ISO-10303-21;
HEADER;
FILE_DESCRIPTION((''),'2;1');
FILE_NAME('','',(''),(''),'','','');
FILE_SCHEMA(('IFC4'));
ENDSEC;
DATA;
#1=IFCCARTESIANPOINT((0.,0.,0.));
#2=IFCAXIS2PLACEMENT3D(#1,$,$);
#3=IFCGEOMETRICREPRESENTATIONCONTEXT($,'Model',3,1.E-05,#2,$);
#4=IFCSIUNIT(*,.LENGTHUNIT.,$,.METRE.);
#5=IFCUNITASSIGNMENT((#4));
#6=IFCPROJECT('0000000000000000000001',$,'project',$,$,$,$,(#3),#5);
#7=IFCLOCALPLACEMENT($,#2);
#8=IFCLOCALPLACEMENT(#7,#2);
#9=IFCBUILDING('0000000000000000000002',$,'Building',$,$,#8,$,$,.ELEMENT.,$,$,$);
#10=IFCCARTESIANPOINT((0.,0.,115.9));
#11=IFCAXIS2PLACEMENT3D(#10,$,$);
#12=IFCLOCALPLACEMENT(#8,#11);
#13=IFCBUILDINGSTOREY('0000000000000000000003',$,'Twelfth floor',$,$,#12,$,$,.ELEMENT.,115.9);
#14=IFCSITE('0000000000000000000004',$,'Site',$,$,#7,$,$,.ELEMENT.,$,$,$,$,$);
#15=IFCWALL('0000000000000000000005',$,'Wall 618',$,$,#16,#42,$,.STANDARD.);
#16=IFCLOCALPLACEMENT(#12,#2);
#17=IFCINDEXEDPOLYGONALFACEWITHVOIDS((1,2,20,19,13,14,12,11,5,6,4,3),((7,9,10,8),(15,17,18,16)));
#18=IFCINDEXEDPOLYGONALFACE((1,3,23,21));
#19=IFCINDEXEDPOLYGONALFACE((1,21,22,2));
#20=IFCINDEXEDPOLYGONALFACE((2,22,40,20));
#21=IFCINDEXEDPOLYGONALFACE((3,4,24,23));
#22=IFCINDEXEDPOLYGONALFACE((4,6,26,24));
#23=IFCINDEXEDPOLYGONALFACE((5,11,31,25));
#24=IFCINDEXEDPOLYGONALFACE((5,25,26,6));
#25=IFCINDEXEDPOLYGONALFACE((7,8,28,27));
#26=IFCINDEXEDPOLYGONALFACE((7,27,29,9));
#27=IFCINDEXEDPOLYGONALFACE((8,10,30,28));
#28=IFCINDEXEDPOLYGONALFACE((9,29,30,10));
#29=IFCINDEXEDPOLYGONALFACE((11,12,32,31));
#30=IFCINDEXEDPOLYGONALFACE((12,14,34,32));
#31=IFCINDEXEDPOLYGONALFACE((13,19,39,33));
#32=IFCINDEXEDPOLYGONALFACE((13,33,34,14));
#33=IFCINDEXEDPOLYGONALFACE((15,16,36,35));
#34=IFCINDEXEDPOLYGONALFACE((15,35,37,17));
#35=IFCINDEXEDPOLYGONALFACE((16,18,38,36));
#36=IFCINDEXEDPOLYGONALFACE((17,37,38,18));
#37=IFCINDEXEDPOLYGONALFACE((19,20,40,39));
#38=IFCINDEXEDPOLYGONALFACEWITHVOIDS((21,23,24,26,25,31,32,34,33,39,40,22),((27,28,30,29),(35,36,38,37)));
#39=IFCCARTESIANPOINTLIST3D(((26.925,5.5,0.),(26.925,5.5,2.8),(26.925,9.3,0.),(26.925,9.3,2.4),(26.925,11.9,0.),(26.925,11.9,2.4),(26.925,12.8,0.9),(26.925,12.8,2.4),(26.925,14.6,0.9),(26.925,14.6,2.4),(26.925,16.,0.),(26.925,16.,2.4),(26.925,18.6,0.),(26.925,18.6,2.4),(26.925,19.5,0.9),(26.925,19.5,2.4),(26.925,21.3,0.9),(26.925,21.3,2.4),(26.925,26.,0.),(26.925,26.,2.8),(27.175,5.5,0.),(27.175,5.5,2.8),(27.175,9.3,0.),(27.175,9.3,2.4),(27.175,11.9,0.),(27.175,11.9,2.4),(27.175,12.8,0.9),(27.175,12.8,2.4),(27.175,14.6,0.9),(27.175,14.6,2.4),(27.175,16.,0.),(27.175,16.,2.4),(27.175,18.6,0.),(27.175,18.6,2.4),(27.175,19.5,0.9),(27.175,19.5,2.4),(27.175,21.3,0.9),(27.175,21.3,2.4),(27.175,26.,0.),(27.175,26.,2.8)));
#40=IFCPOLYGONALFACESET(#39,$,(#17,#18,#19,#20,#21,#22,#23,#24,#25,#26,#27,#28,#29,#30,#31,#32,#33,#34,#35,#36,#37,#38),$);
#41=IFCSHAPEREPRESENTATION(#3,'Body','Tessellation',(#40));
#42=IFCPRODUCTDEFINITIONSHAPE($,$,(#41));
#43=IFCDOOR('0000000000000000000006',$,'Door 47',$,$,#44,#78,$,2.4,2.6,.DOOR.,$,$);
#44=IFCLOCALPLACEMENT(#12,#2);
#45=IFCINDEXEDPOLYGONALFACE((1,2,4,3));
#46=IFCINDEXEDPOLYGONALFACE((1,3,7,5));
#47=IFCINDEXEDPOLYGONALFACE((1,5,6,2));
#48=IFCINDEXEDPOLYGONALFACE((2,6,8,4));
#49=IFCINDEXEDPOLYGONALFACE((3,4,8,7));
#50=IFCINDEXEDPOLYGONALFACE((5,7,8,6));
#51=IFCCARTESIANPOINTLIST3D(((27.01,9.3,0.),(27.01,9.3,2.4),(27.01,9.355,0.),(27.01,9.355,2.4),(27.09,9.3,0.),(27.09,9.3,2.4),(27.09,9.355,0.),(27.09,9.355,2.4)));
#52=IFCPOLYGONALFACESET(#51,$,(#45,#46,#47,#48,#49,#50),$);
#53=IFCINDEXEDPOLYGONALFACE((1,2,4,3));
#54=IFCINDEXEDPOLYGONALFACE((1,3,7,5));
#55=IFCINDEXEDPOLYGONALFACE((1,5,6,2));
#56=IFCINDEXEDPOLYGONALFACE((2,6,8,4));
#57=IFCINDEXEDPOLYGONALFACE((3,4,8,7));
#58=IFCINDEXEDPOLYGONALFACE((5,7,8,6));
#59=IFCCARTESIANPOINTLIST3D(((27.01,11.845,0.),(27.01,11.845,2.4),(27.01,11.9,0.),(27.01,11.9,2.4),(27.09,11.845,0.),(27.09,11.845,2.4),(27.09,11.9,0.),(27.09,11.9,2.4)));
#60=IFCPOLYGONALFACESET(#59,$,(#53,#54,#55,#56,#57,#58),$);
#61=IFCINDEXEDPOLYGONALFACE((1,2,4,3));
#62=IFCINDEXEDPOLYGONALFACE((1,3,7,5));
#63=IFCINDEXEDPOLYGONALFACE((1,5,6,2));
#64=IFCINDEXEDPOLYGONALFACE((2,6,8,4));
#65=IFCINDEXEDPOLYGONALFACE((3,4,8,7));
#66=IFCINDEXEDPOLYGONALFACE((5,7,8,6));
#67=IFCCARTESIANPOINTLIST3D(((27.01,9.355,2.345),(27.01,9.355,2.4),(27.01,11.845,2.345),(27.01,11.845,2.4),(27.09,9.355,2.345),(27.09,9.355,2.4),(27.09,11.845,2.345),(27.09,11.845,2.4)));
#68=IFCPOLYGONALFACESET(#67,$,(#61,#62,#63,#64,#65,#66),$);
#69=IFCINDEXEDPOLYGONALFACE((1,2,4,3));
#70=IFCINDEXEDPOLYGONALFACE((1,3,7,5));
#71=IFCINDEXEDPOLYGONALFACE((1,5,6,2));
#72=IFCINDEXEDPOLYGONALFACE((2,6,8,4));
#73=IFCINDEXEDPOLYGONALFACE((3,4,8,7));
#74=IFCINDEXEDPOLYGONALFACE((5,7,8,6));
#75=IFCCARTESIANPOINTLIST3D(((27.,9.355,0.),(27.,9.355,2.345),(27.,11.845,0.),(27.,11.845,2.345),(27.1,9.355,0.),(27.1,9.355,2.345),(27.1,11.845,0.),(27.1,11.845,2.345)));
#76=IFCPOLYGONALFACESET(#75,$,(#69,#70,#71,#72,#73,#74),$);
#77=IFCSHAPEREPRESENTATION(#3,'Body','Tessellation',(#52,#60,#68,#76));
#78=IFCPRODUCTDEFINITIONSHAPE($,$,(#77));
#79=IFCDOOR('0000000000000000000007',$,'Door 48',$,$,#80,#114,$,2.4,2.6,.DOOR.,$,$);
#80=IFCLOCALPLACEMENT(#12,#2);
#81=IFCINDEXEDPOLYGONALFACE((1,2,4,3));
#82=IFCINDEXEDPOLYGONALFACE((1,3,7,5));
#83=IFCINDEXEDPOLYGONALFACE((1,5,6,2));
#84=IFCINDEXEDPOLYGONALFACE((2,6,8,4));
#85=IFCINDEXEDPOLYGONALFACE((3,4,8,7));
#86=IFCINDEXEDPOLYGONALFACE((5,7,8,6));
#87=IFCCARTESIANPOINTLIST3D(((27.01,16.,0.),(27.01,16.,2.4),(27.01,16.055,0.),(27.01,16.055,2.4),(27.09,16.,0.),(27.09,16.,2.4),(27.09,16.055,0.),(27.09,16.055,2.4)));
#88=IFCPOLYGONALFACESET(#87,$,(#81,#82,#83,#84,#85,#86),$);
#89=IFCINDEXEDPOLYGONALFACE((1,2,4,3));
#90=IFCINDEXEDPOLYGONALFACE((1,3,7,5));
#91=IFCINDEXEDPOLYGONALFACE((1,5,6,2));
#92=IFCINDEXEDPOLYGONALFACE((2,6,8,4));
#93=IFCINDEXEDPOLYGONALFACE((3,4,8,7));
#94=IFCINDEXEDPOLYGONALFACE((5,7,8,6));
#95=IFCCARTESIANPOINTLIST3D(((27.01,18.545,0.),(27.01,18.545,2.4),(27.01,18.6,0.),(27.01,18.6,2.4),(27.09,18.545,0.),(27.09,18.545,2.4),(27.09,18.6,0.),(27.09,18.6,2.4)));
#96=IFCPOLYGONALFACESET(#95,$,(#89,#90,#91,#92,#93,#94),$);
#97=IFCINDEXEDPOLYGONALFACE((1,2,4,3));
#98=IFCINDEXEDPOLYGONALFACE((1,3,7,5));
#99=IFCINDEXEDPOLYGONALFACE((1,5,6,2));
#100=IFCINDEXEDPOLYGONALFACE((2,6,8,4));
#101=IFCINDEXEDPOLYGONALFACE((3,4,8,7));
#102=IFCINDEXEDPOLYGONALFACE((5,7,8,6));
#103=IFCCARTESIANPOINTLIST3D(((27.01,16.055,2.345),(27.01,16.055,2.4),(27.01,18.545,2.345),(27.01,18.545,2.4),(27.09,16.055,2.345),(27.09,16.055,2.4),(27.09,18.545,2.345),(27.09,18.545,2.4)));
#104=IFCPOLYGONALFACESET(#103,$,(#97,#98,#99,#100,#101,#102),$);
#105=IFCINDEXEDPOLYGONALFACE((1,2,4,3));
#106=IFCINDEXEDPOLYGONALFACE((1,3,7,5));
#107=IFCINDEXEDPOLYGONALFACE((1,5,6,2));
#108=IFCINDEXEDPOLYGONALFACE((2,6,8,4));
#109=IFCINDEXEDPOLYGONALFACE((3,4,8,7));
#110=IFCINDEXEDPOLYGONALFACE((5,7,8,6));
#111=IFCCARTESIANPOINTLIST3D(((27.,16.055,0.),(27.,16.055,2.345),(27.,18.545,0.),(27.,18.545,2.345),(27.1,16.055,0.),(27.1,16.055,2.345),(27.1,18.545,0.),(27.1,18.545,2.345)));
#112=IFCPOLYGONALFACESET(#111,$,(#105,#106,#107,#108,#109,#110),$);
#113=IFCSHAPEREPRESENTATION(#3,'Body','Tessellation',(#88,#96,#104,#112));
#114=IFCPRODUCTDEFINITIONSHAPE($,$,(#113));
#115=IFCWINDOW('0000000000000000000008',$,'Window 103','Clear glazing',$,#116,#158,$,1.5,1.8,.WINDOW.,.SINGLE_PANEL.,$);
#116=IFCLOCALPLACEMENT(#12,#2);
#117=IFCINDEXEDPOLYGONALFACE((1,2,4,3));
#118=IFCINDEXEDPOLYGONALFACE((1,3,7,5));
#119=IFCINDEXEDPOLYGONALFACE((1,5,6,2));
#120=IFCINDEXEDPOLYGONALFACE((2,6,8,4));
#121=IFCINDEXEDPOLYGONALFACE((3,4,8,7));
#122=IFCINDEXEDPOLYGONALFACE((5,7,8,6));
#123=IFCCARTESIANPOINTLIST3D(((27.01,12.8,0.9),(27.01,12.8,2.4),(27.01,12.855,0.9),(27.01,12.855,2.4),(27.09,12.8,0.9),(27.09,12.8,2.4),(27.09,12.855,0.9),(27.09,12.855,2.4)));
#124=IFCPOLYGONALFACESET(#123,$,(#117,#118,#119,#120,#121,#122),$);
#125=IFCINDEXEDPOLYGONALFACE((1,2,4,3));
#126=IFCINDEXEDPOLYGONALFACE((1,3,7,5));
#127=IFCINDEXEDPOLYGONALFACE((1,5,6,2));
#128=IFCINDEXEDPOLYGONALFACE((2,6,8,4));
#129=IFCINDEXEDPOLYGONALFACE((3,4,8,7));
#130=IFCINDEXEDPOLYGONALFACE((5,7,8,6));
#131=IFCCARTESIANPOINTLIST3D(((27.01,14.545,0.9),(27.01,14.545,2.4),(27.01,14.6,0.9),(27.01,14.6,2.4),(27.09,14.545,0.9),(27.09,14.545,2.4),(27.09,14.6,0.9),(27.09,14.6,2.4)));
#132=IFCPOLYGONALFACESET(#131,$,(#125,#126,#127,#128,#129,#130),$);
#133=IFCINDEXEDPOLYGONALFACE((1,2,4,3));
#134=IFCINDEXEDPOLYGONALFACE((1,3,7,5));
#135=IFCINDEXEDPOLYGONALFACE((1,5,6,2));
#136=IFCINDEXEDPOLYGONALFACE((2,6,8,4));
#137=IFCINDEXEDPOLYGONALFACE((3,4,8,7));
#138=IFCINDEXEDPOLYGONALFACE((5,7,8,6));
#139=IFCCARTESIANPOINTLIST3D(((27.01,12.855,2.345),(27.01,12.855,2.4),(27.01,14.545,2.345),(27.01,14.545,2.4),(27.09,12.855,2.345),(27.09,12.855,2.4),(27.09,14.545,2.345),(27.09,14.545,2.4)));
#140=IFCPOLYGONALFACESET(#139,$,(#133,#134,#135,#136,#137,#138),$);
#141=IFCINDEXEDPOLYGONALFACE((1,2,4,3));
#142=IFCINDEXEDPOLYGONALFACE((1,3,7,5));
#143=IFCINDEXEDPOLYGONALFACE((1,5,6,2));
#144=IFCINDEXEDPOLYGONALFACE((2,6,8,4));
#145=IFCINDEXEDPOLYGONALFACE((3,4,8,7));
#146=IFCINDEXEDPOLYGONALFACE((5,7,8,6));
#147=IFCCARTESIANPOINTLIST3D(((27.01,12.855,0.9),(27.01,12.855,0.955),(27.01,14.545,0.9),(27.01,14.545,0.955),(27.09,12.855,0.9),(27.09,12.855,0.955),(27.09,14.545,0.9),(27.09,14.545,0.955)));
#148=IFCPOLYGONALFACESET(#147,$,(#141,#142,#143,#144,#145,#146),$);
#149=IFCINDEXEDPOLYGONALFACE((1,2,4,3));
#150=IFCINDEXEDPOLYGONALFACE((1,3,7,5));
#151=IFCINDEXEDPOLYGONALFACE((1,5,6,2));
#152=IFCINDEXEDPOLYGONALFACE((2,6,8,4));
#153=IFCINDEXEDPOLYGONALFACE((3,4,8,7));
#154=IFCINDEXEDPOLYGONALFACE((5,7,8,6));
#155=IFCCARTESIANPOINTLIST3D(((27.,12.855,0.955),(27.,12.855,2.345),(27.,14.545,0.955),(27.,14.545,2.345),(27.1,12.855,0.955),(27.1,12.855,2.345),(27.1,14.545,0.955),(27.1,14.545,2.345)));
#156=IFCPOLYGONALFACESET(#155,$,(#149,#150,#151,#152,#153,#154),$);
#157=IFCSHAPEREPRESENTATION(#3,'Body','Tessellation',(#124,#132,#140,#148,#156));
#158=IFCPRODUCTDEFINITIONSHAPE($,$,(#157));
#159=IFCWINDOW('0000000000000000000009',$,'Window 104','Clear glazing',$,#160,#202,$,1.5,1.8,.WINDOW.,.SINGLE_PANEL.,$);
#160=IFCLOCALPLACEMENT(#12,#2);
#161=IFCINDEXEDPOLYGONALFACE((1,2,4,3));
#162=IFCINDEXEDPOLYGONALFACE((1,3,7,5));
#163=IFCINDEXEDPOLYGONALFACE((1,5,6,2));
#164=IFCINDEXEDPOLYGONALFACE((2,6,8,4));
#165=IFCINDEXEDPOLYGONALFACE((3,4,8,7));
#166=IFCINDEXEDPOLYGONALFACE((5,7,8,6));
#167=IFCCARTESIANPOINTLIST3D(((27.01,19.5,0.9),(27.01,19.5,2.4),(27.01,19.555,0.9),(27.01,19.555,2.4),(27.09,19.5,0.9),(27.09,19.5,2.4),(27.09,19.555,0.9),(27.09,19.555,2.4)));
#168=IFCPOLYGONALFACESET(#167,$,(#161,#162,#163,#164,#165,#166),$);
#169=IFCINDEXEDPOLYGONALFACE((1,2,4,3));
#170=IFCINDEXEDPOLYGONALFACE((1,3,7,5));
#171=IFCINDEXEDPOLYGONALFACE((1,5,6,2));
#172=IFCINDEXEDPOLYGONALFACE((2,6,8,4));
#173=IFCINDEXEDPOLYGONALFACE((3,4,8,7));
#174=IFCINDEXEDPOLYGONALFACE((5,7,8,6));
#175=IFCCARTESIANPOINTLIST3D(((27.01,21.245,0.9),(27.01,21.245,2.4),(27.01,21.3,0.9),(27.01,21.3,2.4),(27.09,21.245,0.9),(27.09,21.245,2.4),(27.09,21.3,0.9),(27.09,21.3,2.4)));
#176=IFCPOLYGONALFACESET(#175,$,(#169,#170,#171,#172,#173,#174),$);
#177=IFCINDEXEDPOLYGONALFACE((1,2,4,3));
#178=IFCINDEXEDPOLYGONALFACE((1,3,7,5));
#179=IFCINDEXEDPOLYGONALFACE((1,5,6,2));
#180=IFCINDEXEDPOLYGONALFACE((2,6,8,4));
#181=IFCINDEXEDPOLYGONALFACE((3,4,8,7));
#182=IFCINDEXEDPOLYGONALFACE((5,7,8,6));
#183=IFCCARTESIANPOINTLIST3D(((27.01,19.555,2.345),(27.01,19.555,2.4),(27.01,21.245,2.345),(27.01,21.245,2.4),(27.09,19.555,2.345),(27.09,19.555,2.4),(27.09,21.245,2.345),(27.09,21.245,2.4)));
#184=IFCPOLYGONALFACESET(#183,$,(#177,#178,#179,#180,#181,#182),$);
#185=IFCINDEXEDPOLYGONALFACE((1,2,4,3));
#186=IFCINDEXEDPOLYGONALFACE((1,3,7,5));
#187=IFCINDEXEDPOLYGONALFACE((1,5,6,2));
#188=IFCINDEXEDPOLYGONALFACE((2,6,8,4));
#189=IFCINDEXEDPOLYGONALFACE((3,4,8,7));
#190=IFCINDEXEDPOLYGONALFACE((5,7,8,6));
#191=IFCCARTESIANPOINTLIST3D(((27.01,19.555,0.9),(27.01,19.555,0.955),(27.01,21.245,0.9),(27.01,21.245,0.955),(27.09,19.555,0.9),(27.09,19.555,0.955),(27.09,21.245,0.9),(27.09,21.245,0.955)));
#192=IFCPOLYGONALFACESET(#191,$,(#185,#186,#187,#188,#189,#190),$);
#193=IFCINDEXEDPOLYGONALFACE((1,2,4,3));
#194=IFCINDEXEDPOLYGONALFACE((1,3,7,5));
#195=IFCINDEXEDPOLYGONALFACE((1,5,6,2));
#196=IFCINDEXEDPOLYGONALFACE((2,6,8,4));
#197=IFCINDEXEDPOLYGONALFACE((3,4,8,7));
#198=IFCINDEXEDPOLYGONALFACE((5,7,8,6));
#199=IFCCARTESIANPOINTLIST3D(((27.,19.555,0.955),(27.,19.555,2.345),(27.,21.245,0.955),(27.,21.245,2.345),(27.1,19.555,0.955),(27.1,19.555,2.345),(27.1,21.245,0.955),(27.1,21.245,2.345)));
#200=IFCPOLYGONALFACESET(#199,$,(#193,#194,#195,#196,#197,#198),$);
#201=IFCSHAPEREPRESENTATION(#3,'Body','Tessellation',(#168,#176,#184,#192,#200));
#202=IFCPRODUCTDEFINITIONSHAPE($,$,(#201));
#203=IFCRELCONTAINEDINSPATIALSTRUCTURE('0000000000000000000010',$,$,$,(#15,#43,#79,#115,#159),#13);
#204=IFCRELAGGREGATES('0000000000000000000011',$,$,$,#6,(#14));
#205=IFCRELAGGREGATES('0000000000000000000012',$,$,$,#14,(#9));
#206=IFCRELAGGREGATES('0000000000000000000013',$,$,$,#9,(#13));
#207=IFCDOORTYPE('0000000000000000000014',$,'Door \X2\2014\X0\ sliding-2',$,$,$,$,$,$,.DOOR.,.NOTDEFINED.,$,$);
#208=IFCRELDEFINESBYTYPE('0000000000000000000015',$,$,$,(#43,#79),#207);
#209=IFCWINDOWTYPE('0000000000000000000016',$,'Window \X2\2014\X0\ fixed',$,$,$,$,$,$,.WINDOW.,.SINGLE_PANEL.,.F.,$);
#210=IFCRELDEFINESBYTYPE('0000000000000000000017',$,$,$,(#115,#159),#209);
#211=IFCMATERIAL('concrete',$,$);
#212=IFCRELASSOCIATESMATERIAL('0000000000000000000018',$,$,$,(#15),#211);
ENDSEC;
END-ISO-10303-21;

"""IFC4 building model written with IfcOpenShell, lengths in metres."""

from ifc_helpers import new_model, si_unit, frame, frame_2d, origin, place, context, project, spatial, rectangle, extrude, material, type_object, element, fill, save


model = new_model("IFC4")

# Units and contexts
model_context = context("Model", 3, precision=1e-05, world=origin())
ifc_project = project(units=[si_unit("LENGTHUNIT", "METRE")], contexts=[model_context])

# Site, building, storey
site_placement = place(None, origin())
site = spatial("IfcSite", under=ifc_project, at=site_placement, Name="Site", CompositionType="ELEMENT")
building_placement = place(site_placement, origin())
building = spatial("IfcBuilding", under=site, at=building_placement, Name="Building", CompositionType="ELEMENT")
storey_placement = place(building_placement, frame((0.0, 0.0, 115.9)))
storey = spatial("IfcBuildingStorey", under=building, at=storey_placement, Name="Twelfth floor", CompositionType="ELEMENT", Elevation=115.9)

# Shared definitions
ifc_material = material(Name="concrete")

# Wall, openings, doors, windows
wall_1_placement = place(storey_placement, frame((27.05, 5.5, 0.0), z_axis=(0.0, 0.0, 1.0), x_axis=(0.0, 1.0, 0.0)))
wall_1 = element("IfcWall", 1, at=wall_1_placement, inside=storey, material=ifc_material, Name="Wall 618", PredefinedType="STANDARD", context=model_context, shape_type="SweptSolid", body=[
    extrude(rectangle(XDim=20.5, YDim=0.25, at=frame_2d((10.25, 0.0))), origin(), (0.0, 0.0, 1.0), 2.8),
])
opening_1_placement = place(storey_placement, frame((27.05, 9.3, 0.0), z_axis=(0.0, 0.0, 1.0), x_axis=(0.0, 1.0, 0.0)))
opening_1 = element("IfcOpeningElement", 2, at=opening_1_placement, cuts=wall_1, PredefinedType="OPENING", context=model_context, shape_type="SweptSolid", body=[
    extrude(rectangle(XDim=2.6, YDim=0.31, at=frame_2d((1.3, 0.0))), origin(), (0.0, 0.0, 1.0), 2.4),
])
opening_2_placement = place(storey_placement, frame((27.05, 12.8, 0.9), z_axis=(0.0, 0.0, 1.0), x_axis=(0.0, 1.0, 0.0)))
opening_2 = element("IfcOpeningElement", 3, at=opening_2_placement, cuts=wall_1, PredefinedType="OPENING", context=model_context, shape_type="SweptSolid", body=[
    extrude(rectangle(XDim=1.8, YDim=0.31, at=frame_2d((0.9, 0.0))), origin(), (0.0, 0.0, 1.0), 1.5),
])
opening_3_placement = place(storey_placement, frame((27.05, 16.0, 0.0), z_axis=(0.0, 0.0, 1.0), x_axis=(0.0, 1.0, 0.0)))
opening_3 = element("IfcOpeningElement", 4, at=opening_3_placement, cuts=wall_1, PredefinedType="OPENING", context=model_context, shape_type="SweptSolid", body=[
    extrude(rectangle(XDim=2.6, YDim=0.31, at=frame_2d((1.3, 0.0))), origin(), (0.0, 0.0, 1.0), 2.4),
])
opening_4_placement = place(storey_placement, frame((27.05, 19.5, 0.9), z_axis=(0.0, 0.0, 1.0), x_axis=(0.0, 1.0, 0.0)))
opening_4 = element("IfcOpeningElement", 5, at=opening_4_placement, cuts=wall_1, PredefinedType="OPENING", context=model_context, shape_type="SweptSolid", body=[
    extrude(rectangle(XDim=1.8, YDim=0.31, at=frame_2d((0.9, 0.0))), origin(), (0.0, 0.0, 1.0), 1.5),
])
door_type = type_object("IfcDoorType", Name="Door — sliding-2", PredefinedType="DOOR")
door_1_placement = place(storey_placement, frame((27.05, 9.3, 0.0), z_axis=(0.0, 0.0, 1.0), x_axis=(0.0, 1.0, 0.0)))
door_1 = element("IfcDoor", 6, at=door_1_placement, inside=storey, type_object=door_type, Name="Door 47", OverallHeight=2.4, OverallWidth=2.6, PredefinedType="DOOR", context=model_context, shape_type="SweptSolid", body=[
    extrude(rectangle(XDim=0.055, YDim=0.08, at=frame_2d((0.0275, 0.0))), origin(), (0.0, 0.0, 1.0), 2.4),
    extrude(rectangle(XDim=0.055, YDim=0.08, at=frame_2d((2.5725, 0.0))), origin(), (0.0, 0.0, 1.0), 2.4),
    extrude(rectangle(XDim=2.49, YDim=0.08, at=frame_2d((1.3, 0.0))), frame((0.0, 0.0, 2.345)), (0.0, 0.0, 1.0), 0.055),
    extrude(rectangle(XDim=2.49, YDim=0.1, at=frame_2d((1.3, 0.0))), origin(), (0.0, 0.0, 1.0), 2.345),
])
fill(opening_1, door_1)
door_2_placement = place(storey_placement, frame((27.05, 16.0, 0.0), z_axis=(0.0, 0.0, 1.0), x_axis=(0.0, 1.0, 0.0)))
door_2 = element("IfcDoor", 7, at=door_2_placement, inside=storey, type_object=door_type, Name="Door 48", OverallHeight=2.4, OverallWidth=2.6, PredefinedType="DOOR", context=model_context, shape_type="SweptSolid", body=[
    extrude(rectangle(XDim=0.055, YDim=0.08, at=frame_2d((0.0275, 0.0))), origin(), (0.0, 0.0, 1.0), 2.4),
    extrude(rectangle(XDim=0.055, YDim=0.08, at=frame_2d((2.5725, 0.0))), origin(), (0.0, 0.0, 1.0), 2.4),
    extrude(rectangle(XDim=2.49, YDim=0.08, at=frame_2d((1.3, 0.0))), frame((0.0, 0.0, 2.345)), (0.0, 0.0, 1.0), 0.055),
    extrude(rectangle(XDim=2.49, YDim=0.1, at=frame_2d((1.3, 0.0))), origin(), (0.0, 0.0, 1.0), 2.345),
])
fill(opening_3, door_2)
window_type = type_object("IfcWindowType", Name="Window — fixed", ParameterTakesPrecedence=False, PartitioningType="SINGLE_PANEL", PredefinedType="WINDOW")
window_1_placement = place(storey_placement, frame((27.05, 12.8, 0.9), z_axis=(0.0, 0.0, 1.0), x_axis=(0.0, 1.0, 0.0)))
window_1 = element("IfcWindow", 8, at=window_1_placement, inside=storey, type_object=window_type, Name="Window 103", Description="Clear glazing", OverallHeight=1.5, OverallWidth=1.8, PartitioningType="SINGLE_PANEL", PredefinedType="WINDOW", context=model_context, shape_type="SweptSolid", body=[
    extrude(rectangle(XDim=0.055, YDim=0.08, at=frame_2d((0.0275, 0.0))), origin(), (0.0, 0.0, 1.0), 1.5),
    extrude(rectangle(XDim=0.055, YDim=0.08, at=frame_2d((1.7725, 0.0))), origin(), (0.0, 0.0, 1.0), 1.5),
    extrude(rectangle(XDim=1.69, YDim=0.08, at=frame_2d((0.9, 0.0))), frame((0.0, 0.0, 1.445)), (0.0, 0.0, 1.0), 0.055),
    extrude(rectangle(XDim=1.69, YDim=0.08, at=frame_2d((0.9, 0.0))), origin(), (0.0, 0.0, 1.0), 0.055),
    extrude(rectangle(XDim=1.69, YDim=0.1, at=frame_2d((0.9, 0.0))), frame((0.0, 0.0, 0.055)), (0.0, 0.0, 1.0), 1.39),
])
fill(opening_2, window_1)
window_2_placement = place(storey_placement, frame((27.05, 19.5, 0.9), z_axis=(0.0, 0.0, 1.0), x_axis=(0.0, 1.0, 0.0)))
window_2 = element("IfcWindow", 9, at=window_2_placement, inside=storey, type_object=window_type, Name="Window 104", Description="Clear glazing", OverallHeight=1.5, OverallWidth=1.8, PartitioningType="SINGLE_PANEL", PredefinedType="WINDOW", context=model_context, shape_type="SweptSolid", body=[
    extrude(rectangle(XDim=0.055, YDim=0.08, at=frame_2d((0.0275, 0.0))), origin(), (0.0, 0.0, 1.0), 1.5),
    extrude(rectangle(XDim=0.055, YDim=0.08, at=frame_2d((1.7725, 0.0))), origin(), (0.0, 0.0, 1.0), 1.5),
    extrude(rectangle(XDim=1.69, YDim=0.08, at=frame_2d((0.9, 0.0))), frame((0.0, 0.0, 1.445)), (0.0, 0.0, 1.0), 0.055),
    extrude(rectangle(XDim=1.69, YDim=0.08, at=frame_2d((0.9, 0.0))), origin(), (0.0, 0.0, 1.0), 0.055),
    extrude(rectangle(XDim=1.69, YDim=0.1, at=frame_2d((0.9, 0.0))), frame((0.0, 0.0, 0.055)), (0.0, 0.0, 1.0), 1.39),
])
fill(opening_4, window_2)

save(model, "model.ifc")
